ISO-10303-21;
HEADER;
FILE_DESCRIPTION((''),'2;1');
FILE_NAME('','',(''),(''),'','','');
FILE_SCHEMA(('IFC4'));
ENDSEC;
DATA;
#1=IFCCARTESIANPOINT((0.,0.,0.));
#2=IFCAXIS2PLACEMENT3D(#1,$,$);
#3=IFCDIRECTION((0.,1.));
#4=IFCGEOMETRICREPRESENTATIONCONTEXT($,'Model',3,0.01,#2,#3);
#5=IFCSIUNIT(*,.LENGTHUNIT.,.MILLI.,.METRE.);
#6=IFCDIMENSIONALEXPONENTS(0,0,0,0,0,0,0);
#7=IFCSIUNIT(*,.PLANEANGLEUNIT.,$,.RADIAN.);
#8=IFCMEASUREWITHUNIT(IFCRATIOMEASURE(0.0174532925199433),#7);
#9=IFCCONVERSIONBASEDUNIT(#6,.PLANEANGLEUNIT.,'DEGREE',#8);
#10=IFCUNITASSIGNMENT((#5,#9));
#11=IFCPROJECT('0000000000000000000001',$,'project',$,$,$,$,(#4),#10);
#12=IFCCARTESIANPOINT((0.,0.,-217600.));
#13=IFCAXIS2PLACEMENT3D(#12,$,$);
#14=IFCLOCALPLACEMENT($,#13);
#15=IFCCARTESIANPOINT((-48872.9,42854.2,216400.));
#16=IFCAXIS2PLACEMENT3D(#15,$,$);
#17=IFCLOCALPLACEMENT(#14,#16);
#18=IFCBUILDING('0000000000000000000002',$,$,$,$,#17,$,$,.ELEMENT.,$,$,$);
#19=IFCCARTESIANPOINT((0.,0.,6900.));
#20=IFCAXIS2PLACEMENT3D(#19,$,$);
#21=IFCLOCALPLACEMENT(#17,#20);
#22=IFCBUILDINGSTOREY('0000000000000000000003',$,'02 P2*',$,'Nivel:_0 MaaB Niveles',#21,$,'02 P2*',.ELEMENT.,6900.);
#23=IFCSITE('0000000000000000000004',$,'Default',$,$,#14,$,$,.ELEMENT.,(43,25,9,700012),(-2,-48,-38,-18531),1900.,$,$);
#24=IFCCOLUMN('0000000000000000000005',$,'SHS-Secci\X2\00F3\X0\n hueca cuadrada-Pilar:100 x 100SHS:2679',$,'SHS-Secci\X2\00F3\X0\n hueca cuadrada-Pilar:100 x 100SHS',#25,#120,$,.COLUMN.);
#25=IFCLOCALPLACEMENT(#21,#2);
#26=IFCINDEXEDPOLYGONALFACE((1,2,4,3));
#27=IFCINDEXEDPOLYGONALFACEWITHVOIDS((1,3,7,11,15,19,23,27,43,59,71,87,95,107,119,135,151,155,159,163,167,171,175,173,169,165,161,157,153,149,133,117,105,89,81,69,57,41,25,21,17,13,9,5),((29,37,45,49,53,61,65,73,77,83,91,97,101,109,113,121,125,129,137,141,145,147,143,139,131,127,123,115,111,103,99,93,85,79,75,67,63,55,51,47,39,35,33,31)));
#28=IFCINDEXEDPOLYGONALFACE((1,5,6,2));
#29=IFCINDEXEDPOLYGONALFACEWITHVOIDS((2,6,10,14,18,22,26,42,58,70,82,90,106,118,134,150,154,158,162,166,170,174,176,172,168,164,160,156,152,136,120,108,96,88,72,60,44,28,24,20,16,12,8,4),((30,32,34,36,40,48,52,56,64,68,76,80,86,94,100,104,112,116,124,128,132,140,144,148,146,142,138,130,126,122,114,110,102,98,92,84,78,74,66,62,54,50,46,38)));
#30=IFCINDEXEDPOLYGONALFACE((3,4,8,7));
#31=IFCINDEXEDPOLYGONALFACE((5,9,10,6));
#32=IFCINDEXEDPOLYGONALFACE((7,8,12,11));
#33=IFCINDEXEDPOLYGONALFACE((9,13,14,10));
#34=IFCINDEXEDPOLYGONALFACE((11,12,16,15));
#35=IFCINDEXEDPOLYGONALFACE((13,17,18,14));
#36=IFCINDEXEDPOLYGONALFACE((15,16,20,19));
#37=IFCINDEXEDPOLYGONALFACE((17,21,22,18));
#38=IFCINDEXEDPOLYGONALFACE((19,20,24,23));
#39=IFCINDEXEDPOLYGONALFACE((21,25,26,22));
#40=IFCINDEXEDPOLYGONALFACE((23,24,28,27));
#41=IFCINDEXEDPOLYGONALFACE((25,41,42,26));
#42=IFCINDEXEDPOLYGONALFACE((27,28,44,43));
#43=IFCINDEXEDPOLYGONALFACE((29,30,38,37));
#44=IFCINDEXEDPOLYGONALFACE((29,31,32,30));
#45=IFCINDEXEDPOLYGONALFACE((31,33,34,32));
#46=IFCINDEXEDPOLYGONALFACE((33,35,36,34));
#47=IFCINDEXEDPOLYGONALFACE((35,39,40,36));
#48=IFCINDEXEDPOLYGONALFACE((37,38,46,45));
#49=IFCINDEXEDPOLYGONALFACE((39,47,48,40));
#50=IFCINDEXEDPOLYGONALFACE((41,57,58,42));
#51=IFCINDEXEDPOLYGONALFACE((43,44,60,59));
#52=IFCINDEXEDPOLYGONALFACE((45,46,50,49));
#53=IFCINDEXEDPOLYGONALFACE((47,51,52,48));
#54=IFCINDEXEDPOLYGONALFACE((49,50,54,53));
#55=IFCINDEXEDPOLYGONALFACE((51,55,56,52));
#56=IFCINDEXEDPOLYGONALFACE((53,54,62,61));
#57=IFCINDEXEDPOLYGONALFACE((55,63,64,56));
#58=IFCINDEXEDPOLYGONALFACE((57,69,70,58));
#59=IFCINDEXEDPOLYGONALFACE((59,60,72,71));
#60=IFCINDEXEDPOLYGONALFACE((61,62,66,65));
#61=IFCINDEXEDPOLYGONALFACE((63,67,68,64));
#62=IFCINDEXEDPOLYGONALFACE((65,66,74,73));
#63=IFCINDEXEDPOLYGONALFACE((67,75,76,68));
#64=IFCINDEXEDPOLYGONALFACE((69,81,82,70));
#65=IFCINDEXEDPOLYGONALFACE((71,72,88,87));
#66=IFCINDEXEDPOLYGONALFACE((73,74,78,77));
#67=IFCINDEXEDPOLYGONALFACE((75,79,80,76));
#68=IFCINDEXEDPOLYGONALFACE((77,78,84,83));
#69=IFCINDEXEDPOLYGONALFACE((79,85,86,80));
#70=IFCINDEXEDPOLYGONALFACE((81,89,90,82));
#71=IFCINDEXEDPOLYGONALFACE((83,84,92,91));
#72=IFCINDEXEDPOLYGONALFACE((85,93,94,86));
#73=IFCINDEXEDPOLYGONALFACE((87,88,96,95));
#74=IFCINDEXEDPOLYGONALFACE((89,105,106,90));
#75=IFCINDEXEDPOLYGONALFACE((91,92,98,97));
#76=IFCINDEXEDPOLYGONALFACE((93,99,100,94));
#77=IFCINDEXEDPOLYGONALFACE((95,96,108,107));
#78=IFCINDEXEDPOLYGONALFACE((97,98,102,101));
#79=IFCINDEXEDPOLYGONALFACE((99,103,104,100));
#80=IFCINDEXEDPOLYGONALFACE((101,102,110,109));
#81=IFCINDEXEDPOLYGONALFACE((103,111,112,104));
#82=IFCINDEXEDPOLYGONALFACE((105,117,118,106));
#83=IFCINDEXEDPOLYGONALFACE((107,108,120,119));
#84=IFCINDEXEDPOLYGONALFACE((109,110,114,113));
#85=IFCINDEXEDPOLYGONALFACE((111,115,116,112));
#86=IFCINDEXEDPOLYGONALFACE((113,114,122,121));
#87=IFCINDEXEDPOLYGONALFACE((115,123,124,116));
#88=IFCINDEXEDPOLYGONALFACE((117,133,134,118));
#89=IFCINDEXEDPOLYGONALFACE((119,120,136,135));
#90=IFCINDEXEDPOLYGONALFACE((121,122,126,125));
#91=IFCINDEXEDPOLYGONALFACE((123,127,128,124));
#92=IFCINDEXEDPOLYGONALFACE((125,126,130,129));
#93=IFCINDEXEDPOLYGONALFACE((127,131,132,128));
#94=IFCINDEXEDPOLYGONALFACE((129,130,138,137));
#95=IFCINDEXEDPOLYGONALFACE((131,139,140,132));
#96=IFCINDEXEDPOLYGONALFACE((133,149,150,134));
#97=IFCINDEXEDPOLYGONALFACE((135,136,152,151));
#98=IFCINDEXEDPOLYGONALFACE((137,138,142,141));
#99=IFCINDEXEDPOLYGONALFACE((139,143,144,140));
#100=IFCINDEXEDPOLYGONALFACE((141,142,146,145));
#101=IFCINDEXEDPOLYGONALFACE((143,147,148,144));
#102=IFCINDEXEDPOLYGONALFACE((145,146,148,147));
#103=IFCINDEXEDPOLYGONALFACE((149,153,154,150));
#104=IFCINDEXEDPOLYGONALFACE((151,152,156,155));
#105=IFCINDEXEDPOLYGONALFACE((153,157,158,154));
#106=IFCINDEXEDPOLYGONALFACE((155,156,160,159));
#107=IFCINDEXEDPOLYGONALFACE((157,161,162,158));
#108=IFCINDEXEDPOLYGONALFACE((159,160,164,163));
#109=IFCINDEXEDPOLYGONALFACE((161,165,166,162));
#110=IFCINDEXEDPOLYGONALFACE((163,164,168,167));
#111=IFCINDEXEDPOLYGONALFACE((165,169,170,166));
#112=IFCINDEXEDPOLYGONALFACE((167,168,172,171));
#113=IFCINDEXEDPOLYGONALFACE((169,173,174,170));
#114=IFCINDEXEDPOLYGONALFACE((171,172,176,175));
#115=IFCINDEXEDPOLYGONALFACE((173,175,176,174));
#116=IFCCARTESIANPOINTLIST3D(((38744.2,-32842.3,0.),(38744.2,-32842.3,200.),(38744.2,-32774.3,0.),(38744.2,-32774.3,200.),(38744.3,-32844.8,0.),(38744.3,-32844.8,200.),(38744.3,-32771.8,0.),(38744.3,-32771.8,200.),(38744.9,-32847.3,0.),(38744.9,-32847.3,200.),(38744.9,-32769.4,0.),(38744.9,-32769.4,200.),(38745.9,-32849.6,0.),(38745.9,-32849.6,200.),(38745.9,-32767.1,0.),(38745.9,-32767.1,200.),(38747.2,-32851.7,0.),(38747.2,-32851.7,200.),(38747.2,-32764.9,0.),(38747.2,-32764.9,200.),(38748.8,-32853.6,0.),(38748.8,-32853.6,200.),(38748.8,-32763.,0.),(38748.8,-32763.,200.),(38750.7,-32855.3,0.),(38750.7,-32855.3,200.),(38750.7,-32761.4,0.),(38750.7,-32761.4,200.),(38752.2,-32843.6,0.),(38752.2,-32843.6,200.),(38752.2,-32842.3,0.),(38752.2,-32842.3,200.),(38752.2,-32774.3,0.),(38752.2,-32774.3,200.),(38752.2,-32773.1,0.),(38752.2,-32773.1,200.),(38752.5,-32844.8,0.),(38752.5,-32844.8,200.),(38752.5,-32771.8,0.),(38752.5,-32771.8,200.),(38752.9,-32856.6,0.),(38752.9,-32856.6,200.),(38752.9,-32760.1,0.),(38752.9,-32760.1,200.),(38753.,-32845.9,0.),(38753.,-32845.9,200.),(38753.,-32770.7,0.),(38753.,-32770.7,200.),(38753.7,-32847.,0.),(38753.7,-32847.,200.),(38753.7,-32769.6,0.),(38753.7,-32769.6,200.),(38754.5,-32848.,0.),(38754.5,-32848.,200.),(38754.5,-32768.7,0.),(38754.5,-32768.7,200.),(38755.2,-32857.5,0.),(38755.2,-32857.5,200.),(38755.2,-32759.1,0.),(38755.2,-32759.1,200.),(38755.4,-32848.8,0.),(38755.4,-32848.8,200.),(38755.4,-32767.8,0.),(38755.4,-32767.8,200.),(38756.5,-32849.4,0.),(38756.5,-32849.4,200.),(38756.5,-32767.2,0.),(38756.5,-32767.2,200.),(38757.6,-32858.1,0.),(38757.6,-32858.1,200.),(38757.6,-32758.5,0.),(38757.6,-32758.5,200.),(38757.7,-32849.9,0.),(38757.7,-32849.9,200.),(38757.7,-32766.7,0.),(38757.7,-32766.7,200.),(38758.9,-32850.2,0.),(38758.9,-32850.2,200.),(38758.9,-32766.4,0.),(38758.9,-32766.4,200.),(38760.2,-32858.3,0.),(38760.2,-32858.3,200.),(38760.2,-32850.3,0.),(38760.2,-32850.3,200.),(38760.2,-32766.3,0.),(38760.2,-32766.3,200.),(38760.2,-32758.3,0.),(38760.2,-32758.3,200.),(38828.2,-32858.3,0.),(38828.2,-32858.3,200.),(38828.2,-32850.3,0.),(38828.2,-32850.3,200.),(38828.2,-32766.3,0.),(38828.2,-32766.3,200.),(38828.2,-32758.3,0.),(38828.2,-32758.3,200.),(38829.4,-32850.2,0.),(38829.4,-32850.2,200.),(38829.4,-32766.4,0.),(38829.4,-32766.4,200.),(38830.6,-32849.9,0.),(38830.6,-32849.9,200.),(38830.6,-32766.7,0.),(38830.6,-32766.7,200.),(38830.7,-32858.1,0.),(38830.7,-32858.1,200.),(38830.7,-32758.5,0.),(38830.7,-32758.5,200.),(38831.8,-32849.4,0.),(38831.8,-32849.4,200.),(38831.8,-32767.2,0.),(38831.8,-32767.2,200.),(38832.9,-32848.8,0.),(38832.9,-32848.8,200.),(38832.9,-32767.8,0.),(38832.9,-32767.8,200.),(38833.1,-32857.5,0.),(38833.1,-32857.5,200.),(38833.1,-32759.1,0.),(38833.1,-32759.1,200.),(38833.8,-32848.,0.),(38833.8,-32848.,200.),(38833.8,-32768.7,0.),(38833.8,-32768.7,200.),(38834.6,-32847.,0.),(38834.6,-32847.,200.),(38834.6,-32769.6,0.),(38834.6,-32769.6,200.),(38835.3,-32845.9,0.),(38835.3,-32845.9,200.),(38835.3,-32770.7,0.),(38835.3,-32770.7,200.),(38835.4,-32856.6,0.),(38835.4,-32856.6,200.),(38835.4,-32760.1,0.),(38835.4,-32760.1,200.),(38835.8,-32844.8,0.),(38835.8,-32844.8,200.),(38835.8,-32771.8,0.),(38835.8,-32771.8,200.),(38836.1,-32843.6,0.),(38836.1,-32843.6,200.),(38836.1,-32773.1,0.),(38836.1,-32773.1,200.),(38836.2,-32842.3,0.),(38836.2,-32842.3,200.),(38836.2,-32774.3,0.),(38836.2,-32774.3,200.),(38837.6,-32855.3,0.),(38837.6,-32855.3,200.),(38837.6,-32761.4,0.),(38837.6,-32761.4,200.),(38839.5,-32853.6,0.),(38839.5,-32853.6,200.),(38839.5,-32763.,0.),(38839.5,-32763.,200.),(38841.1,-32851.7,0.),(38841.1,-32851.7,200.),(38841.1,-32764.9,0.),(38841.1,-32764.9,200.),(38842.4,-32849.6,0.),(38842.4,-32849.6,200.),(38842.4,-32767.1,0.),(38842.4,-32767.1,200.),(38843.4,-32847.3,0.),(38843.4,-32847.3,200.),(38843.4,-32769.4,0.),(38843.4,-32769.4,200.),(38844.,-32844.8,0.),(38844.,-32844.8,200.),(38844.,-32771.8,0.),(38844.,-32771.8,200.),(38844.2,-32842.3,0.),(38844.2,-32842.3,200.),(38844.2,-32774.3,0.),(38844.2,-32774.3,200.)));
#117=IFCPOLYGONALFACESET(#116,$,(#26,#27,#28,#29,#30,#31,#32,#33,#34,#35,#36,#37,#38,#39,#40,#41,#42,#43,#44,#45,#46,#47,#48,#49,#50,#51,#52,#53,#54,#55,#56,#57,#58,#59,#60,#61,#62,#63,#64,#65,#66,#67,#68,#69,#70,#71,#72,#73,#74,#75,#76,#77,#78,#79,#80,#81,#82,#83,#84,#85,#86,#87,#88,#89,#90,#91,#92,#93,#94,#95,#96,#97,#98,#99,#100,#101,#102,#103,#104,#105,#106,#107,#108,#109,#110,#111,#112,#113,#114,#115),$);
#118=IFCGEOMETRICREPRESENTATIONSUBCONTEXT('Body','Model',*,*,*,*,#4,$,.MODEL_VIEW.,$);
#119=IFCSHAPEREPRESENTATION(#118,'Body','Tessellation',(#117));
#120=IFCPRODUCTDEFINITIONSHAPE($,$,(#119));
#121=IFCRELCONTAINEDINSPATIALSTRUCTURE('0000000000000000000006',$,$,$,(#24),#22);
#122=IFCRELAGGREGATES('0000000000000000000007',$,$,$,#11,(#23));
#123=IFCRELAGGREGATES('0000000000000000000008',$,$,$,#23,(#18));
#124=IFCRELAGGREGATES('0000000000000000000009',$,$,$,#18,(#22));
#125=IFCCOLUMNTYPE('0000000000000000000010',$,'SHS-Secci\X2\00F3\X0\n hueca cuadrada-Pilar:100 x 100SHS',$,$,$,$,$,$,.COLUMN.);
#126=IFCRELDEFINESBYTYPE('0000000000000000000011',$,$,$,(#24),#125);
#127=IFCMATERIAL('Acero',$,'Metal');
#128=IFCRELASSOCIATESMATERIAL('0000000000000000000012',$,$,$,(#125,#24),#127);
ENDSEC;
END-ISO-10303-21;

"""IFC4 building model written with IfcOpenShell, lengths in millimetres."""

from ifc_helpers import new_model, entity, si_unit, converted_unit, direction, frame, origin, place, context, subcontext, project, spatial, indexed_curve, outline, extrude, source, transform, mapped, material, type_object, type_shapes, element, save


model = new_model("IFC4")

# Units and contexts
model_context = context("Model", 3, precision=0.01, world=origin(), true_north=direction((0.0, 1.0)))
body_context = subcontext(model_context, "Body", "Model", "MODEL_VIEW")
ifc_project = project(units=[si_unit("LENGTHUNIT", "METRE", prefix="MILLI"), converted_unit("PLANEANGLEUNIT", "DEGREE", entity("IfcRatioMeasure", 0.0174532925199433), si_unit("PLANEANGLEUNIT", "RADIAN"), dimensions=[0, 0, 0, 0, 0, 0, 0])], contexts=[model_context])

# Site, building, storey
site_placement = place(None, frame((0.0, 0.0, -217600.0)))
site = spatial("IfcSite", under=ifc_project, at=site_placement, Name="Default", CompositionType="ELEMENT", RefLatitude=(43, 25, 9, 700012), RefLongitude=(-2, -48, -38, -18531), RefElevation=1900.0)
building_placement = place(site_placement, frame((-48872.9, 42854.2, 216400.0)))
building = spatial("IfcBuilding", under=site, at=building_placement, CompositionType="ELEMENT")
storey_placement = place(building_placement, frame((0.0, 0.0, 6900.0)))
storey = spatial("IfcBuildingStorey", under=building, at=storey_placement, Name="02 P2*", ObjectType="Nivel:_0 MaaB Niveles", LongName="02 P2*", CompositionType="ELEMENT", Elevation=6900.0)

# Column
ifc_material_1 = material(Name="Acero", Category="Metal")
column_type_1 = type_object("IfcColumnType", Name="SHS-Sección hueca cuadrada-Pilar:100 x 100SHS", PredefinedType="COLUMN", material=ifc_material_1)
shared_shape_1 = source(origin(), body_context, "Body", "SweptSolid", [
    extrude(outline(indexed_curve([(-34.0, -50.0), (34.0, -50.0), (36.5, -49.8), (38.9, -49.2), (41.3, -48.3), (43.4, -46.9), (45.3, -45.3), (46.9, -43.4), (48.3, -41.3), (49.2, -38.9), (49.8, -36.5), (50.0, -34.0), (50.0, 34.0), (49.8, 36.5), (49.2, 38.9), (48.3, 41.3), (46.9, 43.4), (45.3, 45.3), (43.4, 46.9), (41.3, 48.3), (38.9, 49.2), (36.5, 49.8), (34.0, 50.0), (-34.0, 50.0), (-36.5, 49.8), (-38.9, 49.2), (-41.3, 48.3), (-43.4, 46.9), (-45.3, 45.3), (-46.9, 43.4), (-48.3, 41.3), (-49.2, 38.9), (-49.8, 36.5), (-50.0, 34.0), (-50.0, -34.0), (-49.8, -36.5), (-49.2, -38.9), (-48.3, -41.3), (-46.9, -43.4), (-45.3, -45.3), (-43.4, -46.9), (-41.3, -48.3), (-38.9, -49.2), (-36.5, -49.8), (-34.0, -50.0)], self_intersect=False), holes=[indexed_curve([(-42.0, 34.0), (-41.9, 35.3), (-41.6, 36.5), (-41.1, 37.6), (-40.5, 38.7), (-39.7, 39.7), (-38.7, 40.5), (-37.6, 41.1), (-36.5, 41.6), (-35.3, 41.9), (-34.0, 42.0), (34.0, 42.0), (35.3, 41.9), (36.5, 41.6), (37.6, 41.1), (38.7, 40.5), (39.7, 39.7), (40.5, 38.7), (41.1, 37.6), (41.6, 36.5), (41.9, 35.3), (42.0, 34.0), (42.0, -34.0), (41.9, -35.3), (41.6, -36.5), (41.1, -37.6), (40.5, -38.7), (39.7, -39.7), (38.7, -40.5), (37.6, -41.1), (36.5, -41.6), (35.3, -41.9), (34.0, -42.0), (-34.0, -42.0), (-35.3, -41.9), (-36.5, -41.6), (-37.6, -41.1), (-38.7, -40.5), (-39.7, -39.7), (-40.5, -38.7), (-41.1, -37.6), (-41.6, -36.5), (-41.9, -35.3), (-42.0, -34.0), (-42.0, 34.0)], self_intersect=False)]), frame((0.0, 0.0, 6900.0), z_axis=(0.0, 0.0, 1.0), x_axis=(0.0, 1.0, 0.0)), (0.0, 0.0, 1.0), 200.0),
])
type_shapes(column_type_1, [shared_shape_1])
column_1_placement = place(storey_placement, frame((38794.2, -32808.3, -6900.0), z_axis=(0.0, 0.0, 1.0), x_axis=(0.0, -1.0, 0.0)))
element("IfcColumn", 1, at=column_1_placement, inside=storey, type_object=column_type_1, material=ifc_material_1, Name="SHS-Sección hueca cuadrada-Pilar:100 x 100SHS:2679", ObjectType="SHS-Sección hueca cuadrada-Pilar:100 x 100SHS", PredefinedType="COLUMN", context=body_context, shape_type="MappedRepresentation", body=[
    mapped(shared_shape_1, transform((0.0, 0.0, 0.0), scale=1.0)),
])

save(model, "model.ifc")
